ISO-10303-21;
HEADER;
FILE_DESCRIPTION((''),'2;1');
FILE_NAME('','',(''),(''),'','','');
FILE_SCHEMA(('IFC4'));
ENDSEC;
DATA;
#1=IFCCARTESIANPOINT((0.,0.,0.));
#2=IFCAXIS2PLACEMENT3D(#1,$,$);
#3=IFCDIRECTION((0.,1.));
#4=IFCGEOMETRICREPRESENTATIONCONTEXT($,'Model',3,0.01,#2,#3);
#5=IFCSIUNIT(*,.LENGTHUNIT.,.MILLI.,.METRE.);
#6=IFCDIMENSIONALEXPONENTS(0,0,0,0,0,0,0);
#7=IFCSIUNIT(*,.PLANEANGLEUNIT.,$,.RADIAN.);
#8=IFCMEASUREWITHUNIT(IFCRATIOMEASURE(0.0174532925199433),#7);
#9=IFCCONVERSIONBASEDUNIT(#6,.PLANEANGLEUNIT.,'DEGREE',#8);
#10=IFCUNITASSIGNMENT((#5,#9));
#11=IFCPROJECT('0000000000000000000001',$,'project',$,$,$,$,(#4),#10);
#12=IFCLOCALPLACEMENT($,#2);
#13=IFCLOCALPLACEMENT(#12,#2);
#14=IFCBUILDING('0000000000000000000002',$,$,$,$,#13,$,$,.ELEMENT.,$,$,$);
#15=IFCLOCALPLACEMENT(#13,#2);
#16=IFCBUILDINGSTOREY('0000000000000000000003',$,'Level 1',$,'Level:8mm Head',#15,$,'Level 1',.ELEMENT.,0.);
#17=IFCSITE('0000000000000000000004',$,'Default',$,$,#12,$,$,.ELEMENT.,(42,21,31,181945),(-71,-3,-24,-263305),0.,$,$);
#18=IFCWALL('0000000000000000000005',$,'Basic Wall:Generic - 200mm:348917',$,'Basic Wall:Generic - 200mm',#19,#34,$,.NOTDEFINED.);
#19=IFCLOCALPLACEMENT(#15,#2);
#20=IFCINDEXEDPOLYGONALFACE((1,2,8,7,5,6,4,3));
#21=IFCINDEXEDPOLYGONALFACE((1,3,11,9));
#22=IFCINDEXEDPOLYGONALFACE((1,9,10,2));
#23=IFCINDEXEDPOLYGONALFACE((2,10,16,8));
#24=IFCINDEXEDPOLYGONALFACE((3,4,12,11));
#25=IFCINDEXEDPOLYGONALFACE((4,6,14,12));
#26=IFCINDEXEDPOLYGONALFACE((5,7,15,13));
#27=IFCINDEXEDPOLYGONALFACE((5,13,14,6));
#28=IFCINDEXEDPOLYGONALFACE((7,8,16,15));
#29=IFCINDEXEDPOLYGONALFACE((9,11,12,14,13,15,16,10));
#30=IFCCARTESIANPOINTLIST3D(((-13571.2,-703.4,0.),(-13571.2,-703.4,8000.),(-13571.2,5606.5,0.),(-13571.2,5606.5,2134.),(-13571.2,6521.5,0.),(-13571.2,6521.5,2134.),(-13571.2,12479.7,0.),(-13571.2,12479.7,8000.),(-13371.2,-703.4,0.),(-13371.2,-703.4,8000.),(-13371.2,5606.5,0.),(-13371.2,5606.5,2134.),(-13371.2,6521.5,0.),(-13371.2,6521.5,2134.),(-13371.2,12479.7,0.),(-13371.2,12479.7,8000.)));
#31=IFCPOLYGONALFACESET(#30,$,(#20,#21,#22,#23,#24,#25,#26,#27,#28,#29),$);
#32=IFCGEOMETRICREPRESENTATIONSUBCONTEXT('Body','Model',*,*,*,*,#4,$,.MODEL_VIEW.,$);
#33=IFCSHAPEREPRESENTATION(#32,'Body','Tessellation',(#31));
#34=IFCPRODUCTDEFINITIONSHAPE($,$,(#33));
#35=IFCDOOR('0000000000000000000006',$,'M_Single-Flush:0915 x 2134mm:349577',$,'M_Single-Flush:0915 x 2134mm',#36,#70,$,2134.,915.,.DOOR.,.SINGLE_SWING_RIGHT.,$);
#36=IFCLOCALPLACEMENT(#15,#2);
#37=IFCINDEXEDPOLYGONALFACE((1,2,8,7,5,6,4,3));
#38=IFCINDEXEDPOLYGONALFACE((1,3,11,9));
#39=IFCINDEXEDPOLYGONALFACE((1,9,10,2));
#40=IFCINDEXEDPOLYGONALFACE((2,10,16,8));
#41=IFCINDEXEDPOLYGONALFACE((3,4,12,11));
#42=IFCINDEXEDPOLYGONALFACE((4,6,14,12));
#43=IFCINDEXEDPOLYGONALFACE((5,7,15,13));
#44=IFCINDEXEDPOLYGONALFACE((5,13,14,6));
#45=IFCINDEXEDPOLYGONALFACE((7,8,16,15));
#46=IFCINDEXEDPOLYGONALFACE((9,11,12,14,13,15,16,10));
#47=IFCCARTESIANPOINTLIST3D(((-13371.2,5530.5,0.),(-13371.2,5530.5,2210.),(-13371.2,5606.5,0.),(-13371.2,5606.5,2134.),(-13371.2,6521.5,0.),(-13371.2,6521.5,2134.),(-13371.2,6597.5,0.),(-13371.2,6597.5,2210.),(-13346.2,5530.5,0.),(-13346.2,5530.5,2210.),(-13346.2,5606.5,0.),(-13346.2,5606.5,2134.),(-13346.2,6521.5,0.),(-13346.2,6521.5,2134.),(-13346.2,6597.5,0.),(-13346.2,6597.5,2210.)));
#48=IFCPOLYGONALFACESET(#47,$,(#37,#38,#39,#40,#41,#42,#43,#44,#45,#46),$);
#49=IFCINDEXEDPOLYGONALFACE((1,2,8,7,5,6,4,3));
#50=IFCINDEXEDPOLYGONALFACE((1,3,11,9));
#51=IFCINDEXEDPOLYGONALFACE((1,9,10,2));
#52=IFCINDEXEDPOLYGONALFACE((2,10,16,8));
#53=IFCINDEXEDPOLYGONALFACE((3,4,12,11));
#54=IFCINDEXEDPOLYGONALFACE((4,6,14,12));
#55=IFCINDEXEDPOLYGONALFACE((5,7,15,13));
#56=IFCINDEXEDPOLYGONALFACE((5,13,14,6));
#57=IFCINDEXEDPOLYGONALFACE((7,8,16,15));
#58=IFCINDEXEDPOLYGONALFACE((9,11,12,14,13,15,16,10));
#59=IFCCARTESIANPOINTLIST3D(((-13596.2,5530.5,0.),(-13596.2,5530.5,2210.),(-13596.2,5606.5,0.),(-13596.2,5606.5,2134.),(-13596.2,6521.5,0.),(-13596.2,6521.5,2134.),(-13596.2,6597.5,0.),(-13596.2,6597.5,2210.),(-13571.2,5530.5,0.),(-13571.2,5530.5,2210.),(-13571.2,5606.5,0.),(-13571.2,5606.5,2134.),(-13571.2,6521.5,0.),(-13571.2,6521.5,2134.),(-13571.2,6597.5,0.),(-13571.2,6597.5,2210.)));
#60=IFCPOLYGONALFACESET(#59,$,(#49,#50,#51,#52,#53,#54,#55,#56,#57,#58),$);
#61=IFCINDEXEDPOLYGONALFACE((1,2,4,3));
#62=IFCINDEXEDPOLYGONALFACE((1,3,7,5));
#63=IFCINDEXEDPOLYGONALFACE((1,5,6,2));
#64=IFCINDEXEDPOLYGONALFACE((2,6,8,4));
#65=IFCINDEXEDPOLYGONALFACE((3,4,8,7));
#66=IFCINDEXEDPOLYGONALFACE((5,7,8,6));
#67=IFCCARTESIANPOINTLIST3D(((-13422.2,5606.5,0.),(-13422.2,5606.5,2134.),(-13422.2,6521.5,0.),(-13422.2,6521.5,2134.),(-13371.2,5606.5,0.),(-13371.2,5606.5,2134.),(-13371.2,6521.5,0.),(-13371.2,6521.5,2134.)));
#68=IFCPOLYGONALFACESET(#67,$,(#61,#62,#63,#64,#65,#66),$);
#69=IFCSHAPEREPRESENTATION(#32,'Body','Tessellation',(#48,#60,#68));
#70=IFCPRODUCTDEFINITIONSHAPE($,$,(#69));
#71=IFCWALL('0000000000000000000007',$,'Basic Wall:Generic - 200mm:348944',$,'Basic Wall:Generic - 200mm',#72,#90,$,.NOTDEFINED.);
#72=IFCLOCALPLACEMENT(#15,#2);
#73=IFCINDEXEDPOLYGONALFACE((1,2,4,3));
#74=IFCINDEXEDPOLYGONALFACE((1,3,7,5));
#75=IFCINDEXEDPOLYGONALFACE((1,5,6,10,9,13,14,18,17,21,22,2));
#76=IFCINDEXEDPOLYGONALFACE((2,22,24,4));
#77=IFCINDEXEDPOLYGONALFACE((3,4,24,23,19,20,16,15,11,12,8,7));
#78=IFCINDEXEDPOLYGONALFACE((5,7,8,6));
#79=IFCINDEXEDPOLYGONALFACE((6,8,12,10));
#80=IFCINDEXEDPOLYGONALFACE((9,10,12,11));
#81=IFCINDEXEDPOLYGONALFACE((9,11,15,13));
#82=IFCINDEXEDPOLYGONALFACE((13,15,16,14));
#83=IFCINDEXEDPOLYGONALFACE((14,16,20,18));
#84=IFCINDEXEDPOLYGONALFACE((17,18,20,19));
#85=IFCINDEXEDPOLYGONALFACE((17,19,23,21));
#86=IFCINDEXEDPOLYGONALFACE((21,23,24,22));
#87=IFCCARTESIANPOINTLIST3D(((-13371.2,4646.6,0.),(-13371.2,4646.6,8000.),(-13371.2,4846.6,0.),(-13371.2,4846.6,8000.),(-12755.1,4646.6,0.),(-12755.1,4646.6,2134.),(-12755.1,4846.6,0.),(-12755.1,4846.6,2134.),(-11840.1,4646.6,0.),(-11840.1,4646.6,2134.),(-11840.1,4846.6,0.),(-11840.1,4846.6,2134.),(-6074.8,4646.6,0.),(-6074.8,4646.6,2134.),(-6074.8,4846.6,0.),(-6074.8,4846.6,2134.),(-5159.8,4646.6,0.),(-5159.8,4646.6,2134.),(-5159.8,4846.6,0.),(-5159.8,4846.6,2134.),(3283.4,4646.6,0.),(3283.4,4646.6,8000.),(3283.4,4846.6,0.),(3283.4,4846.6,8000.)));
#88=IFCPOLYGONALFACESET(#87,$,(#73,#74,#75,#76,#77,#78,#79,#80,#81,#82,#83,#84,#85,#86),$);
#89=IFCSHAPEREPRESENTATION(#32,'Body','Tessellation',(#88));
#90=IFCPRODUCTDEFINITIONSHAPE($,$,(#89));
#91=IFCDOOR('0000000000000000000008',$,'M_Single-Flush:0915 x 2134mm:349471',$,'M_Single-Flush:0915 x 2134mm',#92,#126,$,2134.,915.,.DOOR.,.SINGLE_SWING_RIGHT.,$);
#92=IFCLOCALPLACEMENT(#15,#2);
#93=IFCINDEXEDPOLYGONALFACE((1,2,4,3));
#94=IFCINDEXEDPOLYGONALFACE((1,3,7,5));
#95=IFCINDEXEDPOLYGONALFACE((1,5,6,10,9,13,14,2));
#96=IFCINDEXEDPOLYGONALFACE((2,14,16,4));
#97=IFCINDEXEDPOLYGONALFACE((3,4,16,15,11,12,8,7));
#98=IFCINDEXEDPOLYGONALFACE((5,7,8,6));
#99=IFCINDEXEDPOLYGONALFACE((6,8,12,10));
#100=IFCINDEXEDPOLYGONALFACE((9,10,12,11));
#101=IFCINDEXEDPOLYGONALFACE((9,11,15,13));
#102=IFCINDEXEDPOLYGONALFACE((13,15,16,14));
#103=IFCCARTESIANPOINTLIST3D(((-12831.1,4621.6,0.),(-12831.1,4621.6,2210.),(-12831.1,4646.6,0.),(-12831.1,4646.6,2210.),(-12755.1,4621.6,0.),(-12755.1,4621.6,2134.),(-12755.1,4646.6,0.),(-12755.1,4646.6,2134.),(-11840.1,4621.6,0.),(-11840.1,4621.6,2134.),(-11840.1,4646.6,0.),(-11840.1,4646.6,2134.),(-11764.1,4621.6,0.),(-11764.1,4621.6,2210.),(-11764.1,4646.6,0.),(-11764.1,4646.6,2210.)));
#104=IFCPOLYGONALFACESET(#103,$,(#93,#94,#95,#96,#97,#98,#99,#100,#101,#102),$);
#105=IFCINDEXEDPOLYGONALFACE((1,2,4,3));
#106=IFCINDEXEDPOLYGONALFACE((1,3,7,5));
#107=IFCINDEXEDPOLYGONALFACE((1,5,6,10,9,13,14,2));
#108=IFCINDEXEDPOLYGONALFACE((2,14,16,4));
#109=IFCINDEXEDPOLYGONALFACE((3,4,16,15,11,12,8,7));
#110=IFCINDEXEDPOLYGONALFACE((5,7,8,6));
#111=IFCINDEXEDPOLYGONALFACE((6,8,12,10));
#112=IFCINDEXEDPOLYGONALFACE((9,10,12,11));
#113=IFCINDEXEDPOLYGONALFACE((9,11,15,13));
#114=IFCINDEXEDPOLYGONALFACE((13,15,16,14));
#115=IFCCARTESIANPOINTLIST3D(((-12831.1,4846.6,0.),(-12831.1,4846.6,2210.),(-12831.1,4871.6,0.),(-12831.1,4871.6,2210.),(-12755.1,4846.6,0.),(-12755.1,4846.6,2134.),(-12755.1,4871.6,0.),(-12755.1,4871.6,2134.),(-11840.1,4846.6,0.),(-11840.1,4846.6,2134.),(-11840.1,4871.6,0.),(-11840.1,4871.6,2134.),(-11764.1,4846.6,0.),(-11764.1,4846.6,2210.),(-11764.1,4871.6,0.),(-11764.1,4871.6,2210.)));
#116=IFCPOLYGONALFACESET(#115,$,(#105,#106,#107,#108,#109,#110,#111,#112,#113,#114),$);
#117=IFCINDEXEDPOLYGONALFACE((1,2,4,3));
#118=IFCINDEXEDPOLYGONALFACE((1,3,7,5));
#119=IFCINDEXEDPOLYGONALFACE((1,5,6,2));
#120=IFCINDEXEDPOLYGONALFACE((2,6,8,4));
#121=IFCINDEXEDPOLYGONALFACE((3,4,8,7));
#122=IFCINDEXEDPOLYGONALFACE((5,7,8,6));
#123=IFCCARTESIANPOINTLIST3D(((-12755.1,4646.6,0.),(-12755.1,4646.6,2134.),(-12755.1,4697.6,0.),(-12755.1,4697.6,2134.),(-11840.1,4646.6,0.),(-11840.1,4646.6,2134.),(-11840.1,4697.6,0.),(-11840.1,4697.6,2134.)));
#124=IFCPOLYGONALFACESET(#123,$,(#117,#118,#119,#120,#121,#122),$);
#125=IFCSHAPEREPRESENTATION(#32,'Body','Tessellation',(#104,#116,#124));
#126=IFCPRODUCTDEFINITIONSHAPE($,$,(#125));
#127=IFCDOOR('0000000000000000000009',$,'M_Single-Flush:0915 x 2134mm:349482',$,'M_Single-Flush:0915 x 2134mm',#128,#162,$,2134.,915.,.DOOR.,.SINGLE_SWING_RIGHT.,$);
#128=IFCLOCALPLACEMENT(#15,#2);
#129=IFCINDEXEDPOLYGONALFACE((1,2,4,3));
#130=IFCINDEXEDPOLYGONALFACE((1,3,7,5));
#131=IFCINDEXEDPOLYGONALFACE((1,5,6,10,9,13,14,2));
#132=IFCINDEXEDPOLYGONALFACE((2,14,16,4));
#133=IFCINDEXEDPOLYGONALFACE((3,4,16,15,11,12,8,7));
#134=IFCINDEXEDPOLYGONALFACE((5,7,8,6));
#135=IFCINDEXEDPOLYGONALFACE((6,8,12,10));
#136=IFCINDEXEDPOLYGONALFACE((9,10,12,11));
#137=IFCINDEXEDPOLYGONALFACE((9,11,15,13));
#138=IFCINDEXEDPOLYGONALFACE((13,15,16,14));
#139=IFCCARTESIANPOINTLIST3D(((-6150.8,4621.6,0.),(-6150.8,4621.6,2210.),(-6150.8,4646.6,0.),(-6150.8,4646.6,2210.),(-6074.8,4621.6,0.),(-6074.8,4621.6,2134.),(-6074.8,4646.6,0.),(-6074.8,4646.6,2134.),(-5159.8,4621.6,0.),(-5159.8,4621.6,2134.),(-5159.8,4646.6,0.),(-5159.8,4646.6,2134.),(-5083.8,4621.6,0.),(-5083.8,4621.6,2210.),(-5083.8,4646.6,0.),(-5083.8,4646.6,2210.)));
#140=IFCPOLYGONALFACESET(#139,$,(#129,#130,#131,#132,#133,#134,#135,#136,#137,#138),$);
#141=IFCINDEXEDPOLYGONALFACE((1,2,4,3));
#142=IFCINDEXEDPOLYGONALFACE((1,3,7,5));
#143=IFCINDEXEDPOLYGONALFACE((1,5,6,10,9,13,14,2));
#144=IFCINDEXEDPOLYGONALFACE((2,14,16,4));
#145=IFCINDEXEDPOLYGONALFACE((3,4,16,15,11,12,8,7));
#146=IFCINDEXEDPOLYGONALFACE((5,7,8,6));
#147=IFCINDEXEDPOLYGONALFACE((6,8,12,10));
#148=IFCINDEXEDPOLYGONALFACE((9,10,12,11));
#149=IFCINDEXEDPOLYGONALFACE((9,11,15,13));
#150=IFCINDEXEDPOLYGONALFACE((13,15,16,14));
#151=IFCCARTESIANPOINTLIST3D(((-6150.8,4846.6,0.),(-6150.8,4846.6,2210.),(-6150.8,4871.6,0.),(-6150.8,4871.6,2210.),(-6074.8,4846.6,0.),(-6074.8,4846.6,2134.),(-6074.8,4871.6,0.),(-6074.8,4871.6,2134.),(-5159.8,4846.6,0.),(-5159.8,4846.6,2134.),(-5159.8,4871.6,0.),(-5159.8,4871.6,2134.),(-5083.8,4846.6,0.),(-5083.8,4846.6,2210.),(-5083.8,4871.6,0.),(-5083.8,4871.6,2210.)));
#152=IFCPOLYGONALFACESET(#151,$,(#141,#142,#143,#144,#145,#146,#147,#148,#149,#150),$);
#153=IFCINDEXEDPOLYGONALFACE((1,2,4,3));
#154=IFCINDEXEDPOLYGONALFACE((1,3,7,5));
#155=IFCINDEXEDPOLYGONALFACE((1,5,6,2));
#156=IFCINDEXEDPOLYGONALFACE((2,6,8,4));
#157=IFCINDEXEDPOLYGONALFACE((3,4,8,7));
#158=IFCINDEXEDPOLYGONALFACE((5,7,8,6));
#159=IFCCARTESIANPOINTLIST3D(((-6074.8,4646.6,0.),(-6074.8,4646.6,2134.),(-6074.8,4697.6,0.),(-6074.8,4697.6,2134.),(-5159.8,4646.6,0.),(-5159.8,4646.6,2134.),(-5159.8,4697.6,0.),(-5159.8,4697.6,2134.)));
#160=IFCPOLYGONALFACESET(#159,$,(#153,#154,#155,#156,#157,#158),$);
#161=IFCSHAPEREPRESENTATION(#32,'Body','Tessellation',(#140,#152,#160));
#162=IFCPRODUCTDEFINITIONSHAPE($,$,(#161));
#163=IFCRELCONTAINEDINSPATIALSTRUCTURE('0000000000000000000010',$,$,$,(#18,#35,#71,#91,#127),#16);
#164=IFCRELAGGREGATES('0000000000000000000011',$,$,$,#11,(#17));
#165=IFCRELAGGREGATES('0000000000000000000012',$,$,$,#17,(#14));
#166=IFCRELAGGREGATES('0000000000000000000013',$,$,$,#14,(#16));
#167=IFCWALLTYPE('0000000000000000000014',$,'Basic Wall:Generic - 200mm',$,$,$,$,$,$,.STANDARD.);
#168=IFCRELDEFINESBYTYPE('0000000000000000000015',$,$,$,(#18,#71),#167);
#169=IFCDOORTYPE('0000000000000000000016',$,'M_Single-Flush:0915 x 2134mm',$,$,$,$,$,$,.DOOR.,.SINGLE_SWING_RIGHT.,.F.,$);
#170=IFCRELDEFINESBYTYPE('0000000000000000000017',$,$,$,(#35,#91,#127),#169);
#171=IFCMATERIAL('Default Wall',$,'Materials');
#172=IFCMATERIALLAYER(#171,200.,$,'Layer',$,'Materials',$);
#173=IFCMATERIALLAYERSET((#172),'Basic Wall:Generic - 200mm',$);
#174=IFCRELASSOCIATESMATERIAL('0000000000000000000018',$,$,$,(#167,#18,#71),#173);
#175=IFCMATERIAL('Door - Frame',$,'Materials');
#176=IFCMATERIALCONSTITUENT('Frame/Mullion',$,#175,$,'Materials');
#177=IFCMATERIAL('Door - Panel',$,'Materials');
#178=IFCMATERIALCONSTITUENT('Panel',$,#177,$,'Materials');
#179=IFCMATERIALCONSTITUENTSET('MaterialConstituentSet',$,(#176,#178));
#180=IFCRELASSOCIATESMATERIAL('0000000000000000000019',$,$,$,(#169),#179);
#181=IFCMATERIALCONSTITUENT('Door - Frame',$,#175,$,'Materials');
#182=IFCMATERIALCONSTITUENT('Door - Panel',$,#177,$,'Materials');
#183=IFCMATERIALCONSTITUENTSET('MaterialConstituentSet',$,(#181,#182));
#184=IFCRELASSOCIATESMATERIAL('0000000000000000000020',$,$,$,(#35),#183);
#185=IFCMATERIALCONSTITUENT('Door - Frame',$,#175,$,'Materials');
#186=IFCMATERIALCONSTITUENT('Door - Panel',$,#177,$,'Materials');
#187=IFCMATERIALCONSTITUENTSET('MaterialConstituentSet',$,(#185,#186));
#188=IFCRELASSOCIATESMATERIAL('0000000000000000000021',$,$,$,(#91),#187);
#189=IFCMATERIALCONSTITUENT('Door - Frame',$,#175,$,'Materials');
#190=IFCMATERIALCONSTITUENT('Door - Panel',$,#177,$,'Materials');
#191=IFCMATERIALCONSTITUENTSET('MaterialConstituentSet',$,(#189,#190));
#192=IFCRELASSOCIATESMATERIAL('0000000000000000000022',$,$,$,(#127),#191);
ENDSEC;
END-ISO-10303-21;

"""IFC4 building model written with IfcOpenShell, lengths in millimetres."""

from ifc_helpers import new_model, entity, si_unit, converted_unit, direction, frame, frame_2d, origin, place, context, subcontext, project, spatial, polyline, rectangle, outline, extrude, source, transform, mapped, material, layer, layer_set, layer_usage, constituent, constituent_set, type_object, type_shapes, element, fill, save


model = new_model("IFC4")

# Units and contexts
model_context = context("Model", 3, precision=0.01, world=origin(), true_north=direction((0.0, 1.0)))
body_context = subcontext(model_context, "Body", "Model", "MODEL_VIEW")
ifc_project = project(units=[si_unit("LENGTHUNIT", "METRE", prefix="MILLI"), converted_unit("PLANEANGLEUNIT", "DEGREE", entity("IfcRatioMeasure", 0.0174532925199433), si_unit("PLANEANGLEUNIT", "RADIAN"), dimensions=[0, 0, 0, 0, 0, 0, 0])], contexts=[model_context])

# Site, building, storey
site_placement = place(None, origin())
site = spatial("IfcSite", under=ifc_project, at=site_placement, Name="Default", CompositionType="ELEMENT", RefLatitude=(42, 21, 31, 181945), RefLongitude=(-71, -3, -24, -263305), RefElevation=0.0)
building_placement = place(site_placement, origin())
building = spatial("IfcBuilding", under=site, at=building_placement, CompositionType="ELEMENT")
storey_placement = place(building_placement, origin())
storey = spatial("IfcBuildingStorey", under=building, at=storey_placement, Name="Level 1", ObjectType="Level:8mm Head", LongName="Level 1", CompositionType="ELEMENT", Elevation=0.0)

# Shared definitions
ifc_material_1 = material(Name="Default Wall", Category="Materials")
ifc_layer = layer(ifc_material_1, 200.0, Name="Layer", Category="Materials")
ifc_layer_set = layer_set([ifc_layer], Name="Basic Wall:Generic - 200mm")
wall_type = type_object("IfcWallType", Name="Basic Wall:Generic - 200mm", PredefinedType="STANDARD", material=ifc_layer_set)

# Shared definitions
ifc_material_2 = material(Name="Door - Frame", Category="Materials")
ifc_material_3 = material(Name="Door - Panel", Category="Materials")

# Wall, opening, door
ifc_layer_usage_1 = layer_usage(ifc_layer_set, "AXIS2", "NEGATIVE", 100.0)
wall_1_placement = place(storey_placement, frame((-13471.2, 12479.7, 0.0), z_axis=(0.0, 0.0, 1.0), x_axis=(0.0, -1.0, 0.0)))
wall_1 = element("IfcWall", 1, at=wall_1_placement, inside=storey, type_object=wall_type, material=ifc_layer_usage_1, Name="Basic Wall:Generic - 200mm:348917", ObjectType="Basic Wall:Generic - 200mm", PredefinedType="NOTDEFINED", context=body_context, shape_type="SweptSolid", body=[
    extrude(rectangle(XDim=13183.1, YDim=200.0, at=frame_2d((6591.6, 0.0), x_axis=(-1.0, 0.0))), origin(), (0.0, 0.0, 1.0), 8000.0),
])
opening_1_placement = place(wall_1_placement, frame((5958.2, -100.0, 0.0)))
opening_1 = element("IfcOpeningElement", 2, at=opening_1_placement, cuts=wall_1, PredefinedType="OPENING", context=body_context, shape_type="SweptSolid", body=[
    extrude(rectangle(XDim=915.0, YDim=2134.0, at=frame_2d((1067.0, 457.5), x_axis=(0.0, 1.0))), frame((0.0, 0.0, 0.0), z_axis=(0.0, 1.0, 0.0), x_axis=(0.0, 0.0, 1.0)), (0.0, 0.0, 1.0), 200.0),
])
ifc_constituent_1 = constituent(ifc_material_2, Name="Door - Frame", Category="Materials")
ifc_constituent_2 = constituent(ifc_material_3, Name="Door - Panel", Category="Materials")
ifc_constituent_set_1 = constituent_set(constituents=[ifc_constituent_1, ifc_constituent_2], Name="MaterialConstituentSet")
ifc_constituent_3 = constituent(ifc_material_2, Name="Frame/Mullion", Category="Materials")
ifc_constituent_4 = constituent(ifc_material_3, Name="Panel", Category="Materials")
ifc_constituent_set_2 = constituent_set(constituents=[ifc_constituent_3, ifc_constituent_4], Name="MaterialConstituentSet")
door_type_1 = type_object("IfcDoorType", Name="M_Single-Flush:0915 x 2134mm", OperationType="SINGLE_SWING_RIGHT", ParameterTakesPrecedence=False, PredefinedType="DOOR", material=ifc_constituent_set_2)
shared_shape_1 = source(origin(), body_context, "Body", "SweptSolid", [
    extrude(outline(polyline([(-533.5, -1124.0), (533.5, -1124.0), (533.5, 1086.0), (457.5, 1086.0), (457.5, -1048.0), (-457.5, -1048.0), (-457.5, 1086.0), (-533.5, 1086.0), (-533.5, -1124.0)])), frame((457.5, 200.0, 1086.0), z_axis=(0.0, 1.0, 0.0), x_axis=(1.0, 0.0, 0.0)), (0.0, 0.0, 1.0), 25.0),
    extrude(outline(polyline([(-1124.0, -533.5), (1086.0, -533.5), (1086.0, -457.5), (-1048.0, -457.5), (-1048.0, 457.5), (1086.0, 457.5), (1086.0, 533.5), (-1124.0, 533.5), (-1124.0, -533.5)])), frame((457.5, -25.0, 1086.0), z_axis=(0.0, 1.0, 0.0), x_axis=(0.0, 0.0, -1.0)), (0.0, 0.0, 1.0), 25.0),
    extrude(rectangle(XDim=51.0, YDim=915.0, at=frame_2d((0.0, 0.0), x_axis=(1.0, 0.0))), frame((457.5, 174.5, 0.0), z_axis=(0.0, 0.0, 1.0), x_axis=(0.0, 1.0, 0.0)), (0.0, 0.0, 1.0), 2134.0),
])
type_shapes(door_type_1, [shared_shape_1])
door_1_placement = place(opening_1_placement, origin())
door_1 = element("IfcDoor", 3, at=door_1_placement, inside=storey, type_object=door_type_1, material=ifc_constituent_set_1, Name="M_Single-Flush:0915 x 2134mm:349577", ObjectType="M_Single-Flush:0915 x 2134mm", OperationType="SINGLE_SWING_RIGHT", OverallHeight=2134.0, OverallWidth=915.0, PredefinedType="DOOR", context=body_context, shape_type="MappedRepresentation", body=[
    mapped(shared_shape_1, transform((0.0, 0.0, 0.0), scale=1.0)),
])
fill(opening_1, door_1)

# Wall, openings, doors
ifc_layer_usage_2 = layer_usage(ifc_layer_set, "AXIS2", "NEGATIVE", 100.0)
wall_2_placement = place(storey_placement, frame((-13371.2, 4746.6, 0.0)))
wall_2 = element("IfcWall", 4, at=wall_2_placement, inside=storey, type_object=wall_type, material=ifc_layer_usage_2, Name="Basic Wall:Generic - 200mm:348944", ObjectType="Basic Wall:Generic - 200mm", PredefinedType="NOTDEFINED", context=body_context, shape_type="SweptSolid", body=[
    extrude(rectangle(XDim=16654.6, YDim=200.0, at=frame_2d((8327.3, 0.0), x_axis=(-1.0, 0.0))), origin(), (0.0, 0.0, 1.0), 8000.0),
])
opening_2_placement = place(wall_2_placement, frame((1531.1, 100.0, 0.0)))
opening_2 = element("IfcOpeningElement", 5, at=opening_2_placement, cuts=wall_2, PredefinedType="OPENING", context=body_context, shape_type="SweptSolid", body=[
    extrude(rectangle(XDim=915.0, YDim=2134.0, at=frame_2d((1067.0, 457.5), x_axis=(0.0, 1.0))), frame((0.0, 0.0, 0.0), z_axis=(0.0, -1.0, 0.0), x_axis=(0.0, 0.0, 1.0)), (0.0, 0.0, 1.0), 200.0),
])
opening_3_placement = place(wall_2_placement, frame((8211.4, 100.0, 0.0)))
opening_3 = element("IfcOpeningElement", 6, at=opening_3_placement, cuts=wall_2, PredefinedType="OPENING", context=body_context, shape_type="SweptSolid", body=[
    extrude(rectangle(XDim=915.0, YDim=2134.0, at=frame_2d((1067.0, 457.5), x_axis=(0.0, 1.0))), frame((0.0, 0.0, 0.0), z_axis=(0.0, -1.0, 0.0), x_axis=(0.0, 0.0, 1.0)), (0.0, 0.0, 1.0), 200.0),
])
ifc_constituent_5 = constituent(ifc_material_2, Name="Door - Frame", Category="Materials")
ifc_constituent_6 = constituent(ifc_material_3, Name="Door - Panel", Category="Materials")
ifc_constituent_set_3 = constituent_set(constituents=[ifc_constituent_5, ifc_constituent_6], Name="MaterialConstituentSet")
door_2_placement = place(opening_2_placement, frame((0.0, 0.0, 0.0), z_axis=(0.0, 0.0, 1.0), x_axis=(-1.0, 0.0, 0.0)))
door_2 = element("IfcDoor", 7, at=door_2_placement, inside=storey, type_object=door_type_1, material=ifc_constituent_set_3, Name="M_Single-Flush:0915 x 2134mm:349471", ObjectType="M_Single-Flush:0915 x 2134mm", OperationType="SINGLE_SWING_RIGHT", OverallHeight=2134.0, OverallWidth=915.0, PredefinedType="DOOR", context=body_context, shape_type="MappedRepresentation", body=[
    mapped(shared_shape_1, transform((0.0, 0.0, 0.0), scale=1.0)),
])
fill(opening_2, door_2)
ifc_constituent_7 = constituent(ifc_material_2, Name="Door - Frame", Category="Materials")
ifc_constituent_8 = constituent(ifc_material_3, Name="Door - Panel", Category="Materials")
ifc_constituent_set_4 = constituent_set(constituents=[ifc_constituent_7, ifc_constituent_8], Name="MaterialConstituentSet")
door_3_placement = place(opening_3_placement, frame((0.0, 0.0, 0.0), z_axis=(0.0, 0.0, 1.0), x_axis=(-1.0, 0.0, 0.0)))
door_3 = element("IfcDoor", 8, at=door_3_placement, inside=storey, type_object=door_type_1, material=ifc_constituent_set_4, Name="M_Single-Flush:0915 x 2134mm:349482", ObjectType="M_Single-Flush:0915 x 2134mm", OperationType="SINGLE_SWING_RIGHT", OverallHeight=2134.0, OverallWidth=915.0, PredefinedType="DOOR", context=body_context, shape_type="MappedRepresentation", body=[
    mapped(shared_shape_1, transform((0.0, 0.0, 0.0), scale=1.0)),
])
fill(opening_3, door_3)

save(model, "model.ifc")
